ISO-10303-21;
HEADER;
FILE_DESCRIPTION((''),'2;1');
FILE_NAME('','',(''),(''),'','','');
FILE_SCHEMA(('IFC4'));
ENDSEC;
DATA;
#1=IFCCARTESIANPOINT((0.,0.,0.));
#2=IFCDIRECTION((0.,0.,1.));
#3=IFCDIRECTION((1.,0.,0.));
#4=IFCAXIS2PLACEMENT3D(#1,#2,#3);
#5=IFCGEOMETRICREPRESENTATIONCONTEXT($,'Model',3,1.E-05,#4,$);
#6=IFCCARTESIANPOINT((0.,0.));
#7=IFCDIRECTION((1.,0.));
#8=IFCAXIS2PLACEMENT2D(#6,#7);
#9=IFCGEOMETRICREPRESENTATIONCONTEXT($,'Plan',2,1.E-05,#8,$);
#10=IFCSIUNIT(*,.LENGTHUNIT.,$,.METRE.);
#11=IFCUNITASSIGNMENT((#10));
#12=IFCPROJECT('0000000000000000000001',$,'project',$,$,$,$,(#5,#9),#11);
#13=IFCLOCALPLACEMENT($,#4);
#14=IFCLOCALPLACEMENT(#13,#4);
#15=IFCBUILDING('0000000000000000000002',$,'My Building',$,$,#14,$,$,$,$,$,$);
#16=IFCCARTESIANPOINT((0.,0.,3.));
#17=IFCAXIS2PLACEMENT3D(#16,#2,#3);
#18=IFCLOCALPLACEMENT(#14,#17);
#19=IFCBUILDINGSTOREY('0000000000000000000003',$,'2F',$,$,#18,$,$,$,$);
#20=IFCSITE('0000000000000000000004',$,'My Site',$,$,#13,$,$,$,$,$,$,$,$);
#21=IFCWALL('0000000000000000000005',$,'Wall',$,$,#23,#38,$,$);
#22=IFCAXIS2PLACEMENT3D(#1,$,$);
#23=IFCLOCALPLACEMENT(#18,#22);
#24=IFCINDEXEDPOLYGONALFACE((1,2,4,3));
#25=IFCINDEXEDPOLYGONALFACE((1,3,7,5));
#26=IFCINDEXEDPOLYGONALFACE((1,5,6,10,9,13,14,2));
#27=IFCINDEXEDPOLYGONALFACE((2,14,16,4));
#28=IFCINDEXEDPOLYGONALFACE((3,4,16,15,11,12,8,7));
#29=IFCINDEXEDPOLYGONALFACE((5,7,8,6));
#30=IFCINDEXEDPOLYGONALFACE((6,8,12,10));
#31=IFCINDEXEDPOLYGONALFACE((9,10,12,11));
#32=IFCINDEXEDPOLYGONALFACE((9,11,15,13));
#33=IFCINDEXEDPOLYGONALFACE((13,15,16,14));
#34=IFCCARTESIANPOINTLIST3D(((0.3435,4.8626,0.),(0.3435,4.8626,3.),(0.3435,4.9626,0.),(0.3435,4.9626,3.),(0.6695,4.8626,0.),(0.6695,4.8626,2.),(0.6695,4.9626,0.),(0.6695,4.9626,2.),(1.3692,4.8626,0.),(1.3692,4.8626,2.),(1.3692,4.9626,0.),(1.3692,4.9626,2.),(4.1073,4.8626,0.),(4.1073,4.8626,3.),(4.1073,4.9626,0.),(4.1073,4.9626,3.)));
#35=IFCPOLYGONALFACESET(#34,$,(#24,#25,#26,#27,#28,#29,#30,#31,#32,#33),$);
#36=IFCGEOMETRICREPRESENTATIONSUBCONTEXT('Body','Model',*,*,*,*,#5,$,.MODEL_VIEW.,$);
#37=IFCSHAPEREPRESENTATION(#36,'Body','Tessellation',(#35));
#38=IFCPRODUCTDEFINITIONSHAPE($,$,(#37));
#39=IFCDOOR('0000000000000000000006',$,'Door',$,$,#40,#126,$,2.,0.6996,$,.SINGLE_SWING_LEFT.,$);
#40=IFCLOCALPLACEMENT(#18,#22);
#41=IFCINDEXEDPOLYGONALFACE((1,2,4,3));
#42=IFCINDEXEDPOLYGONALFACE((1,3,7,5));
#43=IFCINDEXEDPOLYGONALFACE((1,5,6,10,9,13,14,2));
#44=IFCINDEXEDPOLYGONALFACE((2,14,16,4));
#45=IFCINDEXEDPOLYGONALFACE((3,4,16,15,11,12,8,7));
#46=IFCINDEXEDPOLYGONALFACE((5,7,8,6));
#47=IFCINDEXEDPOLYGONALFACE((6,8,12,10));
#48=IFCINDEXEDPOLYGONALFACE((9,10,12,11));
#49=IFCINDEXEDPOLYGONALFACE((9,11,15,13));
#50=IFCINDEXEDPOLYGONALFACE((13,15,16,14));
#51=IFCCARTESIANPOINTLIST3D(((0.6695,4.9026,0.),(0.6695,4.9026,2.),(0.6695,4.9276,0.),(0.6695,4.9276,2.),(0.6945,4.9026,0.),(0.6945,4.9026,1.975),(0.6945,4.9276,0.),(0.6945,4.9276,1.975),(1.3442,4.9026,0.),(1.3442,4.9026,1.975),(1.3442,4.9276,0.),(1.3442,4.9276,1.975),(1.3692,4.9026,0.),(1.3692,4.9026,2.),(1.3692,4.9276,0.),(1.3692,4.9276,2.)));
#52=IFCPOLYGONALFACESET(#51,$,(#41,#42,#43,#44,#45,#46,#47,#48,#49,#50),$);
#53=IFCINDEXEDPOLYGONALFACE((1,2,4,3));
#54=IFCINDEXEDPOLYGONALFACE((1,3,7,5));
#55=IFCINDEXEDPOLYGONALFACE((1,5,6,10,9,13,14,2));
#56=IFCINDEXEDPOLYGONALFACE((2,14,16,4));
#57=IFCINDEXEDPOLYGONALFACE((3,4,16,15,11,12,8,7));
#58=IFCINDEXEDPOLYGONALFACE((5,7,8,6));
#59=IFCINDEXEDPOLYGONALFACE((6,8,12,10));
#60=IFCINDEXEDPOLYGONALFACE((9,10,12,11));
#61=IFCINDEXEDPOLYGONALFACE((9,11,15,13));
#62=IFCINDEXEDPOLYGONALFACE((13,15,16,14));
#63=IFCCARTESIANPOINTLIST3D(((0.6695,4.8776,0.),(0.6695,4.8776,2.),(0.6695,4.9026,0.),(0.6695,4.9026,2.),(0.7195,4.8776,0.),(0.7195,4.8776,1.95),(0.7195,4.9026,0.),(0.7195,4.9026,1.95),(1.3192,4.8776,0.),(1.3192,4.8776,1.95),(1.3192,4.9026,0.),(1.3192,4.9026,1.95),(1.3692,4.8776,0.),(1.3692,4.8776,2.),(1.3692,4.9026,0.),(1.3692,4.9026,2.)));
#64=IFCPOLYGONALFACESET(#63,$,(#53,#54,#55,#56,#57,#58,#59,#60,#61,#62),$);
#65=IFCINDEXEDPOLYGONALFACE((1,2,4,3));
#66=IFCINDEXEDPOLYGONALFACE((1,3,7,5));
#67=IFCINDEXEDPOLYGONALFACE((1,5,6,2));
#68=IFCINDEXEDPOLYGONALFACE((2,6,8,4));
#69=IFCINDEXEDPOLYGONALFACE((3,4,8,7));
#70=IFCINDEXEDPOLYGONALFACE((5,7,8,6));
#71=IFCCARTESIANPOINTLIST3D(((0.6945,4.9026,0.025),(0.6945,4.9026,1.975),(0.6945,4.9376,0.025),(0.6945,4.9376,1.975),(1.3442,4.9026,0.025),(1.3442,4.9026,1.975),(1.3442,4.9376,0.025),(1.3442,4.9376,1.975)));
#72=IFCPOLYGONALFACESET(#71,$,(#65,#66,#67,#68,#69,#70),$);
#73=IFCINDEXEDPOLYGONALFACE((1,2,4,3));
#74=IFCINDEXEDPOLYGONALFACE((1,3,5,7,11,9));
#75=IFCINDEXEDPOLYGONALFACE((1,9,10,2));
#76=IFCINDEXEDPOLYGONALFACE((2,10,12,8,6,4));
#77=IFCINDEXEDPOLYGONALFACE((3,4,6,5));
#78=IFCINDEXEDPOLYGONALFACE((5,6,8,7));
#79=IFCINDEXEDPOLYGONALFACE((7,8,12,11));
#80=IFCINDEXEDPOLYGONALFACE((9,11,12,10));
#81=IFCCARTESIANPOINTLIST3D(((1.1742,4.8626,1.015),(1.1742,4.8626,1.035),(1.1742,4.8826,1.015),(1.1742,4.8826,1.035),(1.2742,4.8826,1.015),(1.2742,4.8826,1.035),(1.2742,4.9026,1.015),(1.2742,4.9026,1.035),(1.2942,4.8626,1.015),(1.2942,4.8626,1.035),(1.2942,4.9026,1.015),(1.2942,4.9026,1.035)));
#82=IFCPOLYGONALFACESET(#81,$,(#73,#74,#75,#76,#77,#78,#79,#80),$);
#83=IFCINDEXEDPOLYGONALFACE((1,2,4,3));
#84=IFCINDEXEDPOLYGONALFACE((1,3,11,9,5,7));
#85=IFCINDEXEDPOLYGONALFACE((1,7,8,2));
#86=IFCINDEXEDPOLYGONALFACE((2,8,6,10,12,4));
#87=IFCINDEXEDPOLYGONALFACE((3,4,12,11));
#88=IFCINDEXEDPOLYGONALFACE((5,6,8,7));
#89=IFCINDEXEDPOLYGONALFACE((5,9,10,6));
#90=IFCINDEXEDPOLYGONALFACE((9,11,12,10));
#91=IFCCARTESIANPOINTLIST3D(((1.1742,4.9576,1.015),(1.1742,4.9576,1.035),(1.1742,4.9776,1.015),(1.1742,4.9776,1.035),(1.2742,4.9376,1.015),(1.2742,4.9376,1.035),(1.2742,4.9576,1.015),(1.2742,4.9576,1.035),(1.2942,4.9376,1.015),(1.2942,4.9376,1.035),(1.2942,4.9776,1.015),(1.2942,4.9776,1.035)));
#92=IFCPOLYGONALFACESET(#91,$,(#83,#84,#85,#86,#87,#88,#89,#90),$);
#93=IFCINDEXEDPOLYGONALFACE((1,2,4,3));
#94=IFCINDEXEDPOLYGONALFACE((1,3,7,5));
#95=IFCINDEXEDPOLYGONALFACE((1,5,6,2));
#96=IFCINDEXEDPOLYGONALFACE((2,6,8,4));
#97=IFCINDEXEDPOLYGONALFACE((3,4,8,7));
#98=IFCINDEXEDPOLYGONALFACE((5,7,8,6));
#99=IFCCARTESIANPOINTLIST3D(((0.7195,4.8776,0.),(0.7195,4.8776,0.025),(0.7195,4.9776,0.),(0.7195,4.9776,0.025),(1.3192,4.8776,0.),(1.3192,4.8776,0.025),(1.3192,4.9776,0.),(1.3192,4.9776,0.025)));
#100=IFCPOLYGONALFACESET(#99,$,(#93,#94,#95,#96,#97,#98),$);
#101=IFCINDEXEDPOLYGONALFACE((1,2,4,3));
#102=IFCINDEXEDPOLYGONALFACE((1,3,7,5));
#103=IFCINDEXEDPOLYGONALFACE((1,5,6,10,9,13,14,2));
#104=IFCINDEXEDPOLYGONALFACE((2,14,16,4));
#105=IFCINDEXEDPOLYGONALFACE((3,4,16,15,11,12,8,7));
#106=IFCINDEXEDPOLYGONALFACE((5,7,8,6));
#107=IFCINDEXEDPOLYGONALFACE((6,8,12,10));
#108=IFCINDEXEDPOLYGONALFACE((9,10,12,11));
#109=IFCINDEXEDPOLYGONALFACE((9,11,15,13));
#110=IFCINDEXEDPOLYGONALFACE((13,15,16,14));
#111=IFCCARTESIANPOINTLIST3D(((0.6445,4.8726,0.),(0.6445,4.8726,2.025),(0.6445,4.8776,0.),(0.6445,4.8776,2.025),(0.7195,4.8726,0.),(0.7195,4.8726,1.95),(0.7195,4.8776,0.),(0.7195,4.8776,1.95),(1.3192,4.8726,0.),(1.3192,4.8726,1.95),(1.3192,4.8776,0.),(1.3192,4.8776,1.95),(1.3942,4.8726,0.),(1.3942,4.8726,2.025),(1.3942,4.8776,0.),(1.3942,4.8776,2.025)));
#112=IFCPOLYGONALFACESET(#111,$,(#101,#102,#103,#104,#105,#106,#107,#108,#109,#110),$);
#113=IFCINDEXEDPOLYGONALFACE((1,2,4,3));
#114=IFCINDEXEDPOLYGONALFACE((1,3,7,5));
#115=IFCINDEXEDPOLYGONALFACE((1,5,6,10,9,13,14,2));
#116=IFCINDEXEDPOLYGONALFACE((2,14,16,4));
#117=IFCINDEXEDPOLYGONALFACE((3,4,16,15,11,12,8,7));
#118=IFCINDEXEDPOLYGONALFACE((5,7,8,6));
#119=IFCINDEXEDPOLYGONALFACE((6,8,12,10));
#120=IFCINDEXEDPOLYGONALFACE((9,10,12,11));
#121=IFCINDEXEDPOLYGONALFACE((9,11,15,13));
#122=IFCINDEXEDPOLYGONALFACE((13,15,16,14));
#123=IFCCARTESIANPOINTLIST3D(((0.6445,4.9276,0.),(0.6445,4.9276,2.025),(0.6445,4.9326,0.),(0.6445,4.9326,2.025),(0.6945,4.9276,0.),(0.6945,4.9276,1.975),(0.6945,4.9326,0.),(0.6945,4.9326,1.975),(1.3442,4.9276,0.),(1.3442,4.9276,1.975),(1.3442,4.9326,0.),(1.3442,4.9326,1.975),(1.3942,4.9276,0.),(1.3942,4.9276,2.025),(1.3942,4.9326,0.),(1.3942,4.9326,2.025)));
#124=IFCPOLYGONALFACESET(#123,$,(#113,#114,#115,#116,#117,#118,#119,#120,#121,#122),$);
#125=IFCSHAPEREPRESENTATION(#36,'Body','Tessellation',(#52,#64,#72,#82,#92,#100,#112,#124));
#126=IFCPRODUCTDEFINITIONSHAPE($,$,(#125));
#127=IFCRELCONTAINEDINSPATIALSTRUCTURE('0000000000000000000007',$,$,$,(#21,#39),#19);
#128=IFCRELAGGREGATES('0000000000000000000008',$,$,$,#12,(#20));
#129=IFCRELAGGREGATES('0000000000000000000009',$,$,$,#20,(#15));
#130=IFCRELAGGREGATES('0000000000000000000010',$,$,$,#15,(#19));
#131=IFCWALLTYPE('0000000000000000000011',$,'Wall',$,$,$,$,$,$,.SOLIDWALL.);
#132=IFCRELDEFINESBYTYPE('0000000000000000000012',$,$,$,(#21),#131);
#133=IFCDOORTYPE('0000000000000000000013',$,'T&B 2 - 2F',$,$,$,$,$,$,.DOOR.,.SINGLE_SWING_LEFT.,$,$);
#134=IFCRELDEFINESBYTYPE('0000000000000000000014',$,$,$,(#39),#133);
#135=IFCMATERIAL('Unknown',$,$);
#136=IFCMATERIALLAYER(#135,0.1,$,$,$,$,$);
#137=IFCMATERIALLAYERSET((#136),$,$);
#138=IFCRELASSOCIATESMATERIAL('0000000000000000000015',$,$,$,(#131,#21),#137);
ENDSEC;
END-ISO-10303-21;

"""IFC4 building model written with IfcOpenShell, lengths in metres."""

from ifc_helpers import new_model, entity, si_unit, frame, origin_with_axes, origin_2d_with_axis, place, context, subcontext, project, spatial, line, indexed_curve, outline, extrude, shape, source, transform, mapped, material, layer, layer_set, layer_usage, type_object, type_shapes, element, fill, save


model = new_model("IFC4")

# Units and contexts
model_context = context("Model", 3, precision=1e-05, world=origin_with_axes())
plan_context = context("Plan", 2, precision=1e-05, world=origin_2d_with_axis())
body_context_1 = subcontext(model_context, "Body", "Model", "MODEL_VIEW")
body_context_2 = subcontext(plan_context, "Body", "Plan", "PLAN_VIEW")
ifc_project = project(units=[si_unit("LENGTHUNIT", "METRE")], contexts=[model_context, plan_context])

# Site, building, storey
site_placement = place(None, origin_with_axes())
site = spatial("IfcSite", under=ifc_project, at=site_placement, Name="My Site")
building_placement = place(site_placement, origin_with_axes())
building = spatial("IfcBuilding", under=site, at=building_placement, Name="My Building")
storey_placement = place(building_placement, frame((0.0, 0.0, 3.0), z_axis=(0.0, 0.0, 1.0), x_axis=(1.0, 0.0, 0.0)))
storey = spatial("IfcBuildingStorey", under=building, at=storey_placement, Name="2F")

# Shared definitions
ifc_material = material(Name="Unknown")
ifc_layer = layer(ifc_material, 0.1)
ifc_layer_set = layer_set([ifc_layer])
wall_type = type_object("IfcWallType", Name="Wall", PredefinedType="SOLIDWALL", material=ifc_layer_set)

# Wall, opening, door
ifc_layer_usage_1 = layer_usage(ifc_layer_set, "AXIS2", "POSITIVE", 0.0)
wall_1_placement = place(storey_placement, frame((4.2073, 4.9626, 0.0), z_axis=(0.0, 0.0, 1.0), x_axis=(-1.0, 0.0, 0.0)))
wall_1 = element("IfcWall", 1, at=wall_1_placement, inside=storey, type_object=wall_type, material=ifc_layer_usage_1, Name="Wall", context=body_context_1, shape_type="SweptSolid", body=[
    extrude(outline(indexed_curve([(0.1, 0.0), (0.1, 0.1), (3.8638, 0.1), (3.8638, 0.0)], segments=[line(1, 2, 3, 4, 1)])), origin_with_axes(), (0.0, 0.0, 1.0), 3.0),
])
shared_shape_1 = source(origin_with_axes(), body_context_1, "Body", "SweptSolid", [
    extrude(outline(indexed_curve([(0.0, 0.0), (0.6996, 0.0), (0.6996, 2.0), (0.0, 2.0)], segments=[line(1, 2, 3, 4, 1)])), frame((0.0, -0.6, 0.0), z_axis=(0.0, -1.0, 0.0), x_axis=(1.0, 0.0, 0.0)), (0.0, 0.0, -1.0), 1.2),
])
opening_1_placement = place(wall_1_placement, frame((3.5378, 0.085, 0.0), z_axis=(0.0, 0.0, 1.0), x_axis=(-1.0, 0.0, 0.0)))
opening_1 = element("IfcOpeningElement", 2, at=opening_1_placement, cuts=wall_1, PredefinedType="OPENING", context=body_context_1, shape_type="MappedRepresentation", body=[
    mapped(shared_shape_1, transform((0.0, 0.0, 0.0), x_axis=(1.0, 0.0, 0.0), y_axis=(0.0, 1.0, 0.0), z_axis=(0.0, 0.0, 1.0), scale=1.0)),
])
door_type_1 = type_object("IfcDoorType", Name="T&B 2 - 2F", OperationType="SINGLE_SWING_LEFT", PredefinedType="DOOR")
shared_shape_2 = source(origin_with_axes(), body_context_1, "Body", "SweptSolid", [
    extrude(outline(indexed_curve([(0.0, 0.0), (0.0, 2.0), (0.6996, 2.0), (0.6996, 0.0), (0.6746, 0.0), (0.6746, 1.975), (0.025, 1.975), (0.025, 0.0)], segments=[line(1, 2, 3, 4, 5, 6, 7, 8, 1)])), frame((0.0, 0.025, 0.0), z_axis=(0.0, -1.0, 0.0), x_axis=(1.0, 0.0, 0.0)), (0.0, 0.0, -1.0), 0.025),
    extrude(outline(indexed_curve([(0.0, 0.0), (0.0, 2.0), (0.6996, 2.0), (0.6996, 0.0), (0.6496, 0.0), (0.6496, 1.95), (0.05, 1.95), (0.05, 0.0)], segments=[line(1, 2, 3, 4, 5, 6, 7, 8, 1)])), frame((0.0, 0.0, 0.0), z_axis=(0.0, -1.0, 0.0), x_axis=(1.0, 0.0, 0.0)), (0.0, 0.0, -1.0), 0.025),
    extrude(outline(indexed_curve([(0.0, 0.0), (0.6496, 0.0), (0.6496, 0.035), (0.0, 0.035)], segments=[line(1, 2, 3, 4, 1)])), frame((0.025, 0.025, 0.025), z_axis=(0.0, 0.0, 1.0), x_axis=(1.0, 0.0, 0.0)), (0.0, 0.0, 1.0), 1.95),
    extrude(outline(indexed_curve([(0.0, 0.0), (0.0, -0.04), (-0.12, -0.04), (-0.12, -0.02), (-0.02, -0.02), (-0.02, 0.0)], segments=[line(1, 2, 3, 4, 5, 6, 1)])), frame((0.6246, 0.025, 1.015), z_axis=(0.0, 0.0, 1.0), x_axis=(1.0, 0.0, 0.0)), (0.0, 0.0, 1.0), 0.02),
    extrude(outline(indexed_curve([(0.0, 0.0), (0.0, 0.04), (-0.12, 0.04), (-0.12, 0.02), (-0.02, 0.02), (-0.02, 0.0)], segments=[line(1, 2, 3, 4, 5, 6, 1)])), frame((0.6246, 0.06, 1.015), z_axis=(0.0, 0.0, 1.0), x_axis=(1.0, 0.0, 0.0)), (0.0, 0.0, 1.0), 0.02),
    extrude(outline(indexed_curve([(0.0, 0.0), (0.5996, 0.0), (0.5996, 0.1), (0.0, 0.1)], segments=[line(1, 2, 3, 4, 1)])), frame((0.05, 0.0, 0.0), z_axis=(0.0, 0.0, 1.0), x_axis=(1.0, 0.0, 0.0)), (0.0, 0.0, 1.0), 0.025),
    extrude(outline(indexed_curve([(0.0, 0.0), (0.0, 2.025), (0.7496, 2.025), (0.7496, 0.0), (0.6746, 0.0), (0.6746, 1.95), (0.075, 1.95), (0.075, 0.0)], segments=[line(1, 2, 3, 4, 5, 6, 7, 8, 1)])), frame((-0.025, -0.005, 0.0), z_axis=(0.0, -1.0, 0.0), x_axis=(1.0, 0.0, 0.0)), (0.0, 0.0, -1.0), 0.005),
    extrude(outline(indexed_curve([(0.0, 0.0), (0.0, 2.025), (0.7496, 2.025), (0.7496, 0.0), (0.6996, 0.0), (0.6996, 1.975), (0.05, 1.975), (0.05, 0.0)], segments=[line(1, 2, 3, 4, 5, 6, 7, 8, 1)])), frame((-0.025, 0.05, 0.0), z_axis=(0.0, -1.0, 0.0), x_axis=(1.0, 0.0, 0.0)), (0.0, 0.0, -1.0), 0.005),
])
shared_shape_3 = source(origin_with_axes(), body_context_2, "Body", "Curve2D", [
    entity("IfcIndexedPolyCurve", entity("IfcCartesianPointList2D", [[0.0, 0.0], [0.0, 0.05], [0.025, 0.05], [0.025, 0.025], [0.05, 0.025], [0.05, 0.0]]), [entity("IfcLineIndex", [1, 2, 3, 4, 5, 6, 1])]),
    entity("IfcIndexedPolyCurve", entity("IfcCartesianPointList2D", [[0.6996, 0.0], [0.6996, 0.05], [0.6746, 0.05], [0.6746, 0.025], [0.6496, 0.025], [0.6496, 0.0]]), [entity("IfcLineIndex", [1, 2, 3, 4, 5, 6, 1])]),
    entity("IfcTrimmedCurve", entity("IfcEllipse", entity("IfcAxis2Placement2D", entity("IfcCartesianPoint", [0.06, 0.05]), entity("IfcDirection", [1.0, 0.0])), 0.6146, 0.6496), [entity("IfcCartesianPoint", [0.6746, 0.05])], [entity("IfcCartesianPoint", [0.06, 0.6996])], True, "CARTESIAN"),
    entity("IfcIndexedPolyCurve", entity("IfcCartesianPointList2D", [[0.025, 0.05], [0.06, 0.05], [0.06, 0.6996], [0.025, 0.6996]]), [entity("IfcLineIndex", [1, 2, 3, 4, 1])]),
])
type_shapes(door_type_1, [shared_shape_2, shared_shape_3])
door_1_placement = place(opening_1_placement, frame((0.0, 0.0, 0.0), z_axis=(0.0, 0.0, 1.0), x_axis=(1.0, 0.0, 0.0)))
door_1 = element("IfcDoor", 3, at=door_1_placement, inside=storey, type_object=door_type_1, Name="Door", OperationType="SINGLE_SWING_LEFT", OverallHeight=2.0, OverallWidth=0.6996, shapes=[
    shape(body_context_1, "Body", "MappedRepresentation", [mapped(shared_shape_2, transform((0.0, 0.0, 0.0), x_axis=(1.0, 0.0, 0.0), y_axis=(0.0, 1.0, 0.0), z_axis=(0.0, 0.0, 1.0), scale=1.0))]),
    shape(body_context_2, "Body", "MappedRepresentation", [mapped(shared_shape_3, transform((0.0, 0.0, 0.0), x_axis=(1.0, 0.0, 0.0), y_axis=(0.0, 1.0, 0.0), z_axis=(0.0, 0.0, 1.0), scale=1.0))]),
])
fill(opening_1, door_1)

save(model, "model.ifc")
